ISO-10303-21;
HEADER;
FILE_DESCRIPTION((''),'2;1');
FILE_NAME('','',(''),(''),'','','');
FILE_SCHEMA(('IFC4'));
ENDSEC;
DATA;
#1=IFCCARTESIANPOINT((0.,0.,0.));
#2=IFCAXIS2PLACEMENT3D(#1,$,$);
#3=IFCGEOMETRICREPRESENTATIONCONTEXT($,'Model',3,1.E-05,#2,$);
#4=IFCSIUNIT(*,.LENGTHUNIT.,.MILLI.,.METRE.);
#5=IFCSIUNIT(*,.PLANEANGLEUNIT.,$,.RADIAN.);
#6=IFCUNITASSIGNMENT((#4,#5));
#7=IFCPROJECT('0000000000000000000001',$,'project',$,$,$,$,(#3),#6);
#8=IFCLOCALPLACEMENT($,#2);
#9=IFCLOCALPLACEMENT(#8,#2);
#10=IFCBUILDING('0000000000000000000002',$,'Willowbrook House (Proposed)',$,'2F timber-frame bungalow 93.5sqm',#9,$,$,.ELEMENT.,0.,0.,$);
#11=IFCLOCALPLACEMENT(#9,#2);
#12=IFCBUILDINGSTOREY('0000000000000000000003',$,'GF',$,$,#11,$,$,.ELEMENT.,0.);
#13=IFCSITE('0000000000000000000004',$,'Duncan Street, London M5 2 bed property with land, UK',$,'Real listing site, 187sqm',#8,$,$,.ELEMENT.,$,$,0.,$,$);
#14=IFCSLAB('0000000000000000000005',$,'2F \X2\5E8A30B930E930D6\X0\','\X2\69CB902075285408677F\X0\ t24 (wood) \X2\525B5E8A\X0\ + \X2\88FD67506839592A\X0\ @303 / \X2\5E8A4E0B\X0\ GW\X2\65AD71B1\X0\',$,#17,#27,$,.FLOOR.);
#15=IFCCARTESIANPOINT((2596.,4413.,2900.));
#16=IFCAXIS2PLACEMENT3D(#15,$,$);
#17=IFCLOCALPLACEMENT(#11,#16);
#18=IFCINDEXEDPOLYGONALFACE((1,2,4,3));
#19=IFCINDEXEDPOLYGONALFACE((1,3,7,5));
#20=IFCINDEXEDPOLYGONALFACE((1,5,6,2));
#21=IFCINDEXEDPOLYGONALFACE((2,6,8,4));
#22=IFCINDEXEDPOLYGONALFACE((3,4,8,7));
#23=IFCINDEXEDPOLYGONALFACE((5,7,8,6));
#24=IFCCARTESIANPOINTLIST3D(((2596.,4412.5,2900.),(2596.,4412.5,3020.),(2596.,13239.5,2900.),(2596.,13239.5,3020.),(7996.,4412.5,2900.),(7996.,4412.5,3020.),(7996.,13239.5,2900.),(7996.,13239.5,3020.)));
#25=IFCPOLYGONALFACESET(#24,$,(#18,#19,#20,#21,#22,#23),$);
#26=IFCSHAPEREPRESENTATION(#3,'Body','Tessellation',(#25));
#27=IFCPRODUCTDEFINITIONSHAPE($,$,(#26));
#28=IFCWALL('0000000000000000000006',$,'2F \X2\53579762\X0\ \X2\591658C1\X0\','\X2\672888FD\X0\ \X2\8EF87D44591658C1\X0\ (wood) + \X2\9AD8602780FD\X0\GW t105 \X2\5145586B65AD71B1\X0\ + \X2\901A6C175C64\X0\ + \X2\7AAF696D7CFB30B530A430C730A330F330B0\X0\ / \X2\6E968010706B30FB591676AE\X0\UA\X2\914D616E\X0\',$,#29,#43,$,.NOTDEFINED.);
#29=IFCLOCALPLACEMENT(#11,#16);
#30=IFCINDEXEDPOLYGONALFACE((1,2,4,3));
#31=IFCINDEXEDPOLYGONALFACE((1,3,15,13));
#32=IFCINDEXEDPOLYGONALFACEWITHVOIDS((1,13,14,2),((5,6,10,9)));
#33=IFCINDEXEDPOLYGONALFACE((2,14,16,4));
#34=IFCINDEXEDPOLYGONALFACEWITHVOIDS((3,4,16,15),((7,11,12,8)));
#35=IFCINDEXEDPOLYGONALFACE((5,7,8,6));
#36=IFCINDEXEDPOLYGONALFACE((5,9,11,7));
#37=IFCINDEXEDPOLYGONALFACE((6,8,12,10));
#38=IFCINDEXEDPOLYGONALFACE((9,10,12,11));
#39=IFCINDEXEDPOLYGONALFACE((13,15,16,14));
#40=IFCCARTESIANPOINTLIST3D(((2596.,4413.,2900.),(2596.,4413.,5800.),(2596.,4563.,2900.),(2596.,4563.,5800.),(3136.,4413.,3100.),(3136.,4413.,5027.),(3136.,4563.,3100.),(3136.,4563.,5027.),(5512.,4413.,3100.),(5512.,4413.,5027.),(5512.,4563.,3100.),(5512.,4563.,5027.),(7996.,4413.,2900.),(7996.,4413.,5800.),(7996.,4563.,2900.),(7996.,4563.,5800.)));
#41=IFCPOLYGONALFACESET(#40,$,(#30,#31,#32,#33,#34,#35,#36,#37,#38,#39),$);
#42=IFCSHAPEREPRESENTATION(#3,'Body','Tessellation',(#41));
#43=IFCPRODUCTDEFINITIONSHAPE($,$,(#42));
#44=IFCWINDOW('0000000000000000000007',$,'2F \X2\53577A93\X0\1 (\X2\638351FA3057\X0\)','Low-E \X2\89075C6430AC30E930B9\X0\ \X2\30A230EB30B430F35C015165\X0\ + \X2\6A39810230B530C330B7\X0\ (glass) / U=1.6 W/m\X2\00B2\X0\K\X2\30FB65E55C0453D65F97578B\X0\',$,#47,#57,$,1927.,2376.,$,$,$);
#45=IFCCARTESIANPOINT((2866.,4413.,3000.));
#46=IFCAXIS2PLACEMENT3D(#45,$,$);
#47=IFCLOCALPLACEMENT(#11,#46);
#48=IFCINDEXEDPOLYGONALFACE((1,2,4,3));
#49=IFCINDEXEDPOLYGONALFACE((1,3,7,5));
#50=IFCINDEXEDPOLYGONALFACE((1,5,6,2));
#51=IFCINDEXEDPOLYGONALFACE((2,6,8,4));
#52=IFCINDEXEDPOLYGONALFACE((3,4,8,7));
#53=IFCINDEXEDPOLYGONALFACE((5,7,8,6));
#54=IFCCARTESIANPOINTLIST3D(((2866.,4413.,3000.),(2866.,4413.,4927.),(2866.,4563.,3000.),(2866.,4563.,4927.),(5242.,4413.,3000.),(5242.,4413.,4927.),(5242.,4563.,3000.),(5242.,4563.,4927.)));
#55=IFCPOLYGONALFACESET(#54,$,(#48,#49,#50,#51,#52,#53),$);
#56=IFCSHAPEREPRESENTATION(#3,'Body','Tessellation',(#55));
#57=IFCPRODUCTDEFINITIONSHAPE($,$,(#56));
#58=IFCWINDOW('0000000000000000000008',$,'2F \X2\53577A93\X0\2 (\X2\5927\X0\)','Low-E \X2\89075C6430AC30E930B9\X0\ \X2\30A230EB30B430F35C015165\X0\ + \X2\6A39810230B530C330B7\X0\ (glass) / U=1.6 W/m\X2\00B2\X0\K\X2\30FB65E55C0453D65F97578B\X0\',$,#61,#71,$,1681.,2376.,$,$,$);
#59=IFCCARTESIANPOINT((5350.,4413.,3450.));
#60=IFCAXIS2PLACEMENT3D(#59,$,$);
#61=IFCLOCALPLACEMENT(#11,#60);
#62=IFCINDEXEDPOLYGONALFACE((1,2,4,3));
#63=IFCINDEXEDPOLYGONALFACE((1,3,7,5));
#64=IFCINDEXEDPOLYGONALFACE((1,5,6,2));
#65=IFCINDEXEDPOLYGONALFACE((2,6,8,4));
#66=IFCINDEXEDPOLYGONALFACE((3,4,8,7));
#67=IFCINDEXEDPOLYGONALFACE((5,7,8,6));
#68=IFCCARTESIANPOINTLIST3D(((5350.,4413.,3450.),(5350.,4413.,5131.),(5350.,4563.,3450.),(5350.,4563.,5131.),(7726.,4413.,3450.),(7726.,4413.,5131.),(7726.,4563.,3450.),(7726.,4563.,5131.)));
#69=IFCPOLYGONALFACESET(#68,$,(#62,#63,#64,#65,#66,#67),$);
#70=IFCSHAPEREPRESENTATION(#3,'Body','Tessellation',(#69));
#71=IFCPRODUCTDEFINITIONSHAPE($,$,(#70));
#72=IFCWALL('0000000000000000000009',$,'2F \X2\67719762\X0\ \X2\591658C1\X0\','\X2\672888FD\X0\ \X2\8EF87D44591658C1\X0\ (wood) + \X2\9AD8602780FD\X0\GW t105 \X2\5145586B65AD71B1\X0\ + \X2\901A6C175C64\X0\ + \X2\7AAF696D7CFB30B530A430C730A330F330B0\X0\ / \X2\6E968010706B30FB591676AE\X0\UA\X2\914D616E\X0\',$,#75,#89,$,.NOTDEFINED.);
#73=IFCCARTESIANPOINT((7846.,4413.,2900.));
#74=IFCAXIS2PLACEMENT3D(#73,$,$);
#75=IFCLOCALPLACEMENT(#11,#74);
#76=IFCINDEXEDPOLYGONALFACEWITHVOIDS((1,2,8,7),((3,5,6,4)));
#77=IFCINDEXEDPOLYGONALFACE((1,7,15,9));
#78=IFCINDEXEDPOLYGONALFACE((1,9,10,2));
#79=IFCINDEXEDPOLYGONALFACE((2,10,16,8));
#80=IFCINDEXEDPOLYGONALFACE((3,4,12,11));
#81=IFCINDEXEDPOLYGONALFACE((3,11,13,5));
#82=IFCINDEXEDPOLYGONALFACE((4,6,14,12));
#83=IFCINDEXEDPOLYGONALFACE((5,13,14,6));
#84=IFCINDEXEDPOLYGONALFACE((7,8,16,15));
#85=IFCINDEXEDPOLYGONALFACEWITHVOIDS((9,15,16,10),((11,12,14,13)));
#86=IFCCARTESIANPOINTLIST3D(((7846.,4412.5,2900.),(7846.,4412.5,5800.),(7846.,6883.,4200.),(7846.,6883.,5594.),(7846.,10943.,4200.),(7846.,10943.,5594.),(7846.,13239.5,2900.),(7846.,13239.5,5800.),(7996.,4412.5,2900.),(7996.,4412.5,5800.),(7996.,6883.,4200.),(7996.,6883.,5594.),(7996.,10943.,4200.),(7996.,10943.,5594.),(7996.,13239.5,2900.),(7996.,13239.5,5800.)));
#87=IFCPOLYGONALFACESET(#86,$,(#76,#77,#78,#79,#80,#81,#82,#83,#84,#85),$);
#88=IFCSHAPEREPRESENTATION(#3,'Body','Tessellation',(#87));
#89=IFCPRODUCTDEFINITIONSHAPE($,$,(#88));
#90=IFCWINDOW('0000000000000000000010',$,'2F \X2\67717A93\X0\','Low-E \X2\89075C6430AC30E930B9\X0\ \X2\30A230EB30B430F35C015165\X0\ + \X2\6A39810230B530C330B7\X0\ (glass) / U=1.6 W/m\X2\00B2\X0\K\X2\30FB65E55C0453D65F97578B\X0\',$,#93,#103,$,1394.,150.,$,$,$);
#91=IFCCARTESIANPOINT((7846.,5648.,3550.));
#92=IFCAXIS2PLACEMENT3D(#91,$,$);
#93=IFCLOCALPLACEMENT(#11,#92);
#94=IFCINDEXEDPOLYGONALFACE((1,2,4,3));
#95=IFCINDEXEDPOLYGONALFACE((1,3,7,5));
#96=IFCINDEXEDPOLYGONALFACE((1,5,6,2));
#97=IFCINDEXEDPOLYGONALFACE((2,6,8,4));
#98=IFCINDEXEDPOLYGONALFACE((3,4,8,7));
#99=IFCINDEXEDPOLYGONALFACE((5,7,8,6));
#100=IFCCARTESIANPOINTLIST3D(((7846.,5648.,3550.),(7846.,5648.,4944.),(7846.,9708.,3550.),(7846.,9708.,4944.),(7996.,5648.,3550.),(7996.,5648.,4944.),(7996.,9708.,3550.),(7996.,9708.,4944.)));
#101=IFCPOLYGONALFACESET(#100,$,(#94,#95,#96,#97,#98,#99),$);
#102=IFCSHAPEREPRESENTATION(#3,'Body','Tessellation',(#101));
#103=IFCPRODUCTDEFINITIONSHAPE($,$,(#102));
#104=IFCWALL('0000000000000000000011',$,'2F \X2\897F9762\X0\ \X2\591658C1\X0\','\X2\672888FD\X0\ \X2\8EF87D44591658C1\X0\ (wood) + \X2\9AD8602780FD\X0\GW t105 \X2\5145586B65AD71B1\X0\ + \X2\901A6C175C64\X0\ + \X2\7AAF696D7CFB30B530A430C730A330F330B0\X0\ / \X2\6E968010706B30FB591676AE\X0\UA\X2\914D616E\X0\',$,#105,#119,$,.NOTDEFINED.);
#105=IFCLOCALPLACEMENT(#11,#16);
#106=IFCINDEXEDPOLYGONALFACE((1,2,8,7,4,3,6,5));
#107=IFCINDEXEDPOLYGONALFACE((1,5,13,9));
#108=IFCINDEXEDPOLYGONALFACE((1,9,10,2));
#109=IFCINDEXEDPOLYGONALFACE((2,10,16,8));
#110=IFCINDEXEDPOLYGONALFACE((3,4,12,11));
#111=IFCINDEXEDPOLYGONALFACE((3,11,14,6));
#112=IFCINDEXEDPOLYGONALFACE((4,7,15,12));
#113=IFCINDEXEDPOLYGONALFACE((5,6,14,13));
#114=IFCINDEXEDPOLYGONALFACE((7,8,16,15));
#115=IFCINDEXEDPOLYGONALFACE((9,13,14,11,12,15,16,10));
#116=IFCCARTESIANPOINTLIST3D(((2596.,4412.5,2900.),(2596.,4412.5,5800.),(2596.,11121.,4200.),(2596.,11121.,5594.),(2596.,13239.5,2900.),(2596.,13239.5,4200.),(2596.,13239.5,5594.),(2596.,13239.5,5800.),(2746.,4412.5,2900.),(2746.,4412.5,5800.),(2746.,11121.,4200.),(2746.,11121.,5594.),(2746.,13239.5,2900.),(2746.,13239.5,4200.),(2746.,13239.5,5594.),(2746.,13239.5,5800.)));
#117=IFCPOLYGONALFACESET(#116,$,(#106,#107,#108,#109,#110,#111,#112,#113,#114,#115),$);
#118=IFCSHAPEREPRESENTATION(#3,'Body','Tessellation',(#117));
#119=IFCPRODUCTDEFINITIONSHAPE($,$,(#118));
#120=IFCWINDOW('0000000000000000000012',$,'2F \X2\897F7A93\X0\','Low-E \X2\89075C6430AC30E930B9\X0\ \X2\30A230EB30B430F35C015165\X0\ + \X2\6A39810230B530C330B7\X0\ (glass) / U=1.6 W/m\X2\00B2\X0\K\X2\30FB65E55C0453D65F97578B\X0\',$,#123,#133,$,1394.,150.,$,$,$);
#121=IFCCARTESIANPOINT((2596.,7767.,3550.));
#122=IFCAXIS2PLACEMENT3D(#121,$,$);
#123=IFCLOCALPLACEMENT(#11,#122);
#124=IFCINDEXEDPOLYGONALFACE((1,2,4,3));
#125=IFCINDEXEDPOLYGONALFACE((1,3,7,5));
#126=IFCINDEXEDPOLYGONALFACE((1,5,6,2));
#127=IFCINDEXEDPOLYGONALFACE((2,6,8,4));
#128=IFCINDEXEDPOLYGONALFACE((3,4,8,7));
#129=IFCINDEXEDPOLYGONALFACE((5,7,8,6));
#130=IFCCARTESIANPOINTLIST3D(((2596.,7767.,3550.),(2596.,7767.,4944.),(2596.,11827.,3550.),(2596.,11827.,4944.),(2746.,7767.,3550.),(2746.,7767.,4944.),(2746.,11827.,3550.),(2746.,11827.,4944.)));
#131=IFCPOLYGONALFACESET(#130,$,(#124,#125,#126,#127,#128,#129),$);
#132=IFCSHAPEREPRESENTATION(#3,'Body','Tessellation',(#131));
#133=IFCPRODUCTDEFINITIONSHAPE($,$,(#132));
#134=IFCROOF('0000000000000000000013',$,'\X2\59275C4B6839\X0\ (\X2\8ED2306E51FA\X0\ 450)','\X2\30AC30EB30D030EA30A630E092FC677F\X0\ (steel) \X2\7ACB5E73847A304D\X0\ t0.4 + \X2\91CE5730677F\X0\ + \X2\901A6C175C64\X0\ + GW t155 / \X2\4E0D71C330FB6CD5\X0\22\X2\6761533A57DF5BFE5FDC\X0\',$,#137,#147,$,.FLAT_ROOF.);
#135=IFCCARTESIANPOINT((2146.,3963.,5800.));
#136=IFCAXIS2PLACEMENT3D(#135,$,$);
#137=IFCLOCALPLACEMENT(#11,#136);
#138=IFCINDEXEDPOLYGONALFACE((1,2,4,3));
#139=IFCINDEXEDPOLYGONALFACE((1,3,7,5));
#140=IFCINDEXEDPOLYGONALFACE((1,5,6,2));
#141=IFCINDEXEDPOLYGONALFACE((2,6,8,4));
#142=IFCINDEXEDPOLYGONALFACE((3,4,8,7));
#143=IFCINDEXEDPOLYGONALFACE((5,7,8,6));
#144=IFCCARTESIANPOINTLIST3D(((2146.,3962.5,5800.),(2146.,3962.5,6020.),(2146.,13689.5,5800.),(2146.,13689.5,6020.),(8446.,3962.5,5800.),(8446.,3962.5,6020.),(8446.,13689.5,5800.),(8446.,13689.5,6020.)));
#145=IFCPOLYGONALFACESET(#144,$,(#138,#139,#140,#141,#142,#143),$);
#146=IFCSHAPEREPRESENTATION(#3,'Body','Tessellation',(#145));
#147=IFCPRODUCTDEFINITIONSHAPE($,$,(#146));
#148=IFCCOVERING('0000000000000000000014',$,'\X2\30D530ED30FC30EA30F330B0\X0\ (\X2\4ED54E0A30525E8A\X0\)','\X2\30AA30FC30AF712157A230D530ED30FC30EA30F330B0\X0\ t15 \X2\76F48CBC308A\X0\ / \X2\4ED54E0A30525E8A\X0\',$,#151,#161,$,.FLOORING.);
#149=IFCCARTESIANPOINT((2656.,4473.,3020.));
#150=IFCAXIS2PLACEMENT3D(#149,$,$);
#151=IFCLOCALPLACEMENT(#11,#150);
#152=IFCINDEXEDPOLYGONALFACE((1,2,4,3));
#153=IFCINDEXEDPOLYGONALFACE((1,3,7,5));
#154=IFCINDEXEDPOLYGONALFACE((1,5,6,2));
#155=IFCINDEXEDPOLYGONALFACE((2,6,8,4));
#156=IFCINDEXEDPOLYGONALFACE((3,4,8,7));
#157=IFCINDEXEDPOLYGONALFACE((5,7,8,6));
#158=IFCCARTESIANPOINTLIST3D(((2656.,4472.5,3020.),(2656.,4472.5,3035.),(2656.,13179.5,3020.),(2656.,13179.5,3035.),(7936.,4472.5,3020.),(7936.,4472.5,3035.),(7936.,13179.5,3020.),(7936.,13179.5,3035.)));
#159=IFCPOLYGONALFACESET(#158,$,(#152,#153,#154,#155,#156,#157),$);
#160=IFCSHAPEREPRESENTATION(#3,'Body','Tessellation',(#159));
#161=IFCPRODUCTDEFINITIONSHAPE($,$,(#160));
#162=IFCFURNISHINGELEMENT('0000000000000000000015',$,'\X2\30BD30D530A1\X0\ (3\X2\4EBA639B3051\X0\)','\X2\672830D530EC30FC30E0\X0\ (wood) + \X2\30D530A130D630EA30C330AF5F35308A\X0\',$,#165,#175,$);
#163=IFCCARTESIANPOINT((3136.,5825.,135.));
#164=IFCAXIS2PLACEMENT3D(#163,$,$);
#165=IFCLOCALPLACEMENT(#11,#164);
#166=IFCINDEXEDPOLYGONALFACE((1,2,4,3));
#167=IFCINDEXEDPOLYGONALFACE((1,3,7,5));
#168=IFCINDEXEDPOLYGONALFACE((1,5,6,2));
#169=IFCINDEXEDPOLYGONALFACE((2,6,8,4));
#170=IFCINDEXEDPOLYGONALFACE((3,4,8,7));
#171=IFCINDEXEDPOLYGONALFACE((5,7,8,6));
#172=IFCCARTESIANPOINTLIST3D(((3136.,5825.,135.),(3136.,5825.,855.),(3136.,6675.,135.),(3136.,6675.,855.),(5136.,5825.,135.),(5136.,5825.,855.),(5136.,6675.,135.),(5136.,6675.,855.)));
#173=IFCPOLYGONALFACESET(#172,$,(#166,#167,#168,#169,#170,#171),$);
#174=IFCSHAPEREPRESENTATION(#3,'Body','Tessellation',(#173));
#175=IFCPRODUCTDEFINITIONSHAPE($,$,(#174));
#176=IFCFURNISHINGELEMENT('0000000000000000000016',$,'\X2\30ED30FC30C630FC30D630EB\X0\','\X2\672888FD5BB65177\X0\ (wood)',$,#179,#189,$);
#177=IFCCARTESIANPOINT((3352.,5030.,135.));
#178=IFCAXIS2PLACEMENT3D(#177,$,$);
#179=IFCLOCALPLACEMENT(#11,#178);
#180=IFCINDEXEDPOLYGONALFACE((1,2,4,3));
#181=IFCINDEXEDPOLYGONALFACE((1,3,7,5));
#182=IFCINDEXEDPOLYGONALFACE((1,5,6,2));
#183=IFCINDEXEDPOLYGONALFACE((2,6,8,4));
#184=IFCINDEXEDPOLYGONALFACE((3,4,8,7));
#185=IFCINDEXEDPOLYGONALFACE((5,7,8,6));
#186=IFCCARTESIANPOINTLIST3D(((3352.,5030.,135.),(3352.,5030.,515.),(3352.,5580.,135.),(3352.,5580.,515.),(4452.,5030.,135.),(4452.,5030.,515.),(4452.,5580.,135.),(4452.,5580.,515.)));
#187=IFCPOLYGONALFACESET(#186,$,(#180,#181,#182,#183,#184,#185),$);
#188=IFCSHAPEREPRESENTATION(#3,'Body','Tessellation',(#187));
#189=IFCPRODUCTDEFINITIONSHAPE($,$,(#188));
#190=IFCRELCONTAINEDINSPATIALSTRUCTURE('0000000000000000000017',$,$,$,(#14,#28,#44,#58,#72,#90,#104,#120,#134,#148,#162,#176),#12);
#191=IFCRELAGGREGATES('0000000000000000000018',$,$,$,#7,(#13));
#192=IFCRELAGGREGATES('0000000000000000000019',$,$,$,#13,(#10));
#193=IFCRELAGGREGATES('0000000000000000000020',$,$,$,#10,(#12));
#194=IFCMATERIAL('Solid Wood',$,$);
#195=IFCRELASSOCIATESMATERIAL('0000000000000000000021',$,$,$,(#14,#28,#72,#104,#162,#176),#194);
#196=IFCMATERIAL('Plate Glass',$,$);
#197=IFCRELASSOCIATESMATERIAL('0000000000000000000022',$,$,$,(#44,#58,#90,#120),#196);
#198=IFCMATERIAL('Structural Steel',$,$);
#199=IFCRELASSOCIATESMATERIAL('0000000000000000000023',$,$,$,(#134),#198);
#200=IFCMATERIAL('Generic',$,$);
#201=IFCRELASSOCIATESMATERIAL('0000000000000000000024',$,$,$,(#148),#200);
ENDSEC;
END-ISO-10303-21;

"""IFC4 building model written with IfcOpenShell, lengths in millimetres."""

from ifc_helpers import new_model, si_unit, frame, frame_2d, origin, place, context, project, spatial, rectangle, extrude, material, element, fill, save


model = new_model("IFC4")

# Units and contexts
model_context = context("Model", 3, precision=1e-05, world=origin())
ifc_project = project(units=[si_unit("LENGTHUNIT", "METRE", prefix="MILLI"), si_unit("PLANEANGLEUNIT", "RADIAN")], contexts=[model_context])

# Site, building, storey
site_placement = place(None, origin())
site = spatial("IfcSite", under=ifc_project, at=site_placement, Name="Duncan Street, London M5 2 bed property with land, UK", ObjectType="Real listing site, 187sqm", CompositionType="ELEMENT", RefElevation=0.0)
building_placement = place(site_placement, origin())
building = spatial("IfcBuilding", under=site, at=building_placement, Name="Willowbrook House (Proposed)", ObjectType="2F timber-frame bungalow 93.5sqm", CompositionType="ELEMENT", ElevationOfRefHeight=0.0, ElevationOfTerrain=0.0)
storey_placement = place(building_placement, origin())
storey = spatial("IfcBuildingStorey", under=building, at=storey_placement, Name="GF", CompositionType="ELEMENT", Elevation=0.0)

# Slab
ifc_material_1 = material(Name="Solid Wood")
slab_placement = place(storey_placement, frame((2596.0, 4413.0, 2900.0)))
element("IfcSlab", 1, at=slab_placement, inside=storey, material=ifc_material_1, Name="2F 床スラブ", Description="構造用合板 t24 (wood) 剛床 + 製材根太 @303 / 床下 GW断熱", PredefinedType="FLOOR", context=model_context, shape_type="SweptSolid", body=[
    extrude(rectangle(XDim=5400.0, YDim=8827.0, at=frame_2d((2700.0, 4413.0))), frame((2596.0, 4413.0, 2900.0)), (0.0, 0.0, 1.0), 120.0),
])

# Wall, openings, windows
wall_1_placement = place(storey_placement, frame((2596.0, 4413.0, 2900.0)))
wall_1 = element("IfcWall", 2, at=wall_1_placement, inside=storey, material=ifc_material_1, Name="2F 南面 外壁", Description="木製 軸組外壁 (wood) + 高性能GW t105 充填断熱 + 通気層 + 窯業系サイディング / 準耐火・外皮UA配慮", PredefinedType="NOTDEFINED", context=model_context, shape_type="SweptSolid", body=[
    extrude(rectangle(XDim=5400.0, YDim=150.0, at=frame_2d((2700.0, 75.0))), frame((2596.0, 4413.0, 2900.0)), (0.0, 0.0, 1.0), 2900.0),
])
opening_1_placement = place(storey_placement, frame((2866.0, 4413.0, 3000.0)))
opening_1 = element("IfcOpeningElement", 3, at=opening_1_placement, cuts=wall_1, PredefinedType="NOTDEFINED", context=model_context, shape_type="SweptSolid", body=[
    extrude(rectangle(XDim=2376.0, YDim=150.0, at=frame_2d((1188.0, 75.0))), frame((2866.0, 4413.0, 3000.0)), (0.0, 0.0, 1.0), 1927.0),
])
opening_2_placement = place(storey_placement, frame((5350.0, 4413.0, 3450.0)))
opening_2 = element("IfcOpeningElement", 4, at=opening_2_placement, cuts=wall_1, PredefinedType="NOTDEFINED", context=model_context, shape_type="SweptSolid", body=[
    extrude(rectangle(XDim=2376.0, YDim=150.0, at=frame_2d((1188.0, 75.0))), frame((5350.0, 4413.0, 3450.0)), (0.0, 0.0, 1.0), 1681.0),
])
ifc_material_2 = material(Name="Plate Glass")
window_1_placement = place(storey_placement, frame((2866.0, 4413.0, 3000.0)))
window_1 = element("IfcWindow", 5, at=window_1_placement, inside=storey, material=ifc_material_2, Name="2F 南窓1 (掃出し)", Description="Low-E 複層ガラス アルゴン封入 + 樹脂サッシ (glass) / U=1.6 W/m²K・日射取得型", OverallHeight=1927.0, OverallWidth=2376.0, context=model_context, shape_type="SweptSolid", body=[
    extrude(rectangle(XDim=2376.0, YDim=150.0, at=frame_2d((1188.0, 75.0))), frame((2866.0, 4413.0, 3000.0)), (0.0, 0.0, 1.0), 1927.0),
])
fill(opening_1, window_1)
window_2_placement = place(storey_placement, frame((5350.0, 4413.0, 3450.0)))
window_2 = element("IfcWindow", 6, at=window_2_placement, inside=storey, material=ifc_material_2, Name="2F 南窓2 (大)", Description="Low-E 複層ガラス アルゴン封入 + 樹脂サッシ (glass) / U=1.6 W/m²K・日射取得型", OverallHeight=1681.0, OverallWidth=2376.0, context=model_context, shape_type="SweptSolid", body=[
    extrude(rectangle(XDim=2376.0, YDim=150.0, at=frame_2d((1188.0, 75.0))), frame((5350.0, 4413.0, 3450.0)), (0.0, 0.0, 1.0), 1681.0),
])
fill(opening_2, window_2)

# Walls, openings, windows
wall_2_placement = place(storey_placement, frame((7846.0, 4413.0, 2900.0)))
wall_2 = element("IfcWall", 7, at=wall_2_placement, inside=storey, material=ifc_material_1, Name="2F 東面 外壁", Description="木製 軸組外壁 (wood) + 高性能GW t105 充填断熱 + 通気層 + 窯業系サイディング / 準耐火・外皮UA配慮", PredefinedType="NOTDEFINED", context=model_context, shape_type="SweptSolid", body=[
    extrude(rectangle(XDim=150.0, YDim=8827.0, at=frame_2d((75.0, 4413.0))), frame((7846.0, 4413.0, 2900.0)), (0.0, 0.0, 1.0), 2900.0),
])
opening_3_placement = place(storey_placement, frame((7846.0, 5648.0, 3550.0)))
opening_3 = element("IfcOpeningElement", 8, at=opening_3_placement, cuts=wall_2, PredefinedType="NOTDEFINED", context=model_context, shape_type="SweptSolid", body=[
    extrude(rectangle(XDim=150.0, YDim=4060.0, at=frame_2d((75.0, 2030.0))), frame((7846.0, 5648.0, 3550.0)), (0.0, 0.0, 1.0), 1394.0),
])
window_3_placement = place(storey_placement, frame((7846.0, 5648.0, 3550.0)))
window_3 = element("IfcWindow", 9, at=window_3_placement, inside=storey, material=ifc_material_2, Name="2F 東窓", Description="Low-E 複層ガラス アルゴン封入 + 樹脂サッシ (glass) / U=1.6 W/m²K・日射取得型", OverallHeight=1394.0, OverallWidth=150.0, context=model_context, shape_type="SweptSolid", body=[
    extrude(rectangle(XDim=150.0, YDim=4060.0, at=frame_2d((75.0, 2030.0))), frame((7846.0, 5648.0, 3550.0)), (0.0, 0.0, 1.0), 1394.0),
])
fill(opening_3, window_3)
wall_3_placement = place(storey_placement, frame((2596.0, 4413.0, 2900.0)))
wall_3 = element("IfcWall", 10, at=wall_3_placement, inside=storey, material=ifc_material_1, Name="2F 西面 外壁", Description="木製 軸組外壁 (wood) + 高性能GW t105 充填断熱 + 通気層 + 窯業系サイディング / 準耐火・外皮UA配慮", PredefinedType="NOTDEFINED", context=model_context, shape_type="SweptSolid", body=[
    extrude(rectangle(XDim=150.0, YDim=8827.0, at=frame_2d((75.0, 4413.0))), frame((2596.0, 4413.0, 2900.0)), (0.0, 0.0, 1.0), 2900.0),
])
opening_4_placement = place(storey_placement, frame((2596.0, 7767.0, 3550.0)))
opening_4 = element("IfcOpeningElement", 11, at=opening_4_placement, cuts=wall_3, PredefinedType="NOTDEFINED", context=model_context, shape_type="SweptSolid", body=[
    extrude(rectangle(XDim=150.0, YDim=4060.0, at=frame_2d((75.0, 2030.0))), frame((2596.0, 7767.0, 3550.0)), (0.0, 0.0, 1.0), 1394.0),
])
window_4_placement = place(storey_placement, frame((2596.0, 7767.0, 3550.0)))
window_4 = element("IfcWindow", 12, at=window_4_placement, inside=storey, material=ifc_material_2, Name="2F 西窓", Description="Low-E 複層ガラス アルゴン封入 + 樹脂サッシ (glass) / U=1.6 W/m²K・日射取得型", OverallHeight=1394.0, OverallWidth=150.0, context=model_context, shape_type="SweptSolid", body=[
    extrude(rectangle(XDim=150.0, YDim=4060.0, at=frame_2d((75.0, 2030.0))), frame((2596.0, 7767.0, 3550.0)), (0.0, 0.0, 1.0), 1394.0),
])
fill(opening_4, window_4)

# Roof
ifc_material_3 = material(Name="Structural Steel")
roof_placement = place(storey_placement, frame((2146.0, 3963.0, 5800.0)))
element("IfcRoof", 13, at=roof_placement, inside=storey, material=ifc_material_3, Name="大屋根 (軒の出 450)", Description="ガルバリウム鋼板 (steel) 立平葺き t0.4 + 野地板 + 通気層 + GW t155 / 不燃・法22条区域対応", PredefinedType="FLAT_ROOF", context=model_context, shape_type="SweptSolid", body=[
    extrude(rectangle(XDim=6300.0, YDim=9727.0, at=frame_2d((3150.0, 4863.0))), frame((2146.0, 3963.0, 5800.0)), (0.0, 0.0, 1.0), 220.0),
])

# Covering
ifc_material_4 = material(Name="Generic")
covering_placement = place(storey_placement, frame((2656.0, 4473.0, 3020.0)))
element("IfcCovering", 14, at=covering_placement, inside=storey, material=ifc_material_4, Name="フローリング (仕上げ床)", Description="オーク無垢フローリング t15 直貼り / 仕上げ床", PredefinedType="FLOORING", context=model_context, shape_type="SweptSolid", body=[
    extrude(rectangle(XDim=5280.0, YDim=8707.0, at=frame_2d((2640.0, 4353.0))), frame((2656.0, 4473.0, 3020.0)), (0.0, 0.0, 1.0), 15.0),
])

# Furnishing elements
furnishing_1_placement = place(storey_placement, frame((3136.0, 5825.0, 135.0)))
element("IfcFurnishingElement", 15, at=furnishing_1_placement, inside=storey, material=ifc_material_1, Name="ソファ (3人掛け)", Description="木フレーム (wood) + ファブリック張り", context=model_context, shape_type="SweptSolid", body=[
    extrude(rectangle(XDim=2000.0, YDim=850.0, at=frame_2d((1000.0, 425.0))), frame((3136.0, 5825.0, 135.0)), (0.0, 0.0, 1.0), 720.0),
])
furnishing_2_placement = place(storey_placement, frame((3352.0, 5030.0, 135.0)))
element("IfcFurnishingElement", 16, at=furnishing_2_placement, inside=storey, material=ifc_material_1, Name="ローテーブル", Description="木製家具 (wood)", context=model_context, shape_type="SweptSolid", body=[
    extrude(rectangle(XDim=1100.0, YDim=550.0, at=frame_2d((550.0, 275.0))), frame((3352.0, 5030.0, 135.0)), (0.0, 0.0, 1.0), 380.0),
])

save(model, "model.ifc")
